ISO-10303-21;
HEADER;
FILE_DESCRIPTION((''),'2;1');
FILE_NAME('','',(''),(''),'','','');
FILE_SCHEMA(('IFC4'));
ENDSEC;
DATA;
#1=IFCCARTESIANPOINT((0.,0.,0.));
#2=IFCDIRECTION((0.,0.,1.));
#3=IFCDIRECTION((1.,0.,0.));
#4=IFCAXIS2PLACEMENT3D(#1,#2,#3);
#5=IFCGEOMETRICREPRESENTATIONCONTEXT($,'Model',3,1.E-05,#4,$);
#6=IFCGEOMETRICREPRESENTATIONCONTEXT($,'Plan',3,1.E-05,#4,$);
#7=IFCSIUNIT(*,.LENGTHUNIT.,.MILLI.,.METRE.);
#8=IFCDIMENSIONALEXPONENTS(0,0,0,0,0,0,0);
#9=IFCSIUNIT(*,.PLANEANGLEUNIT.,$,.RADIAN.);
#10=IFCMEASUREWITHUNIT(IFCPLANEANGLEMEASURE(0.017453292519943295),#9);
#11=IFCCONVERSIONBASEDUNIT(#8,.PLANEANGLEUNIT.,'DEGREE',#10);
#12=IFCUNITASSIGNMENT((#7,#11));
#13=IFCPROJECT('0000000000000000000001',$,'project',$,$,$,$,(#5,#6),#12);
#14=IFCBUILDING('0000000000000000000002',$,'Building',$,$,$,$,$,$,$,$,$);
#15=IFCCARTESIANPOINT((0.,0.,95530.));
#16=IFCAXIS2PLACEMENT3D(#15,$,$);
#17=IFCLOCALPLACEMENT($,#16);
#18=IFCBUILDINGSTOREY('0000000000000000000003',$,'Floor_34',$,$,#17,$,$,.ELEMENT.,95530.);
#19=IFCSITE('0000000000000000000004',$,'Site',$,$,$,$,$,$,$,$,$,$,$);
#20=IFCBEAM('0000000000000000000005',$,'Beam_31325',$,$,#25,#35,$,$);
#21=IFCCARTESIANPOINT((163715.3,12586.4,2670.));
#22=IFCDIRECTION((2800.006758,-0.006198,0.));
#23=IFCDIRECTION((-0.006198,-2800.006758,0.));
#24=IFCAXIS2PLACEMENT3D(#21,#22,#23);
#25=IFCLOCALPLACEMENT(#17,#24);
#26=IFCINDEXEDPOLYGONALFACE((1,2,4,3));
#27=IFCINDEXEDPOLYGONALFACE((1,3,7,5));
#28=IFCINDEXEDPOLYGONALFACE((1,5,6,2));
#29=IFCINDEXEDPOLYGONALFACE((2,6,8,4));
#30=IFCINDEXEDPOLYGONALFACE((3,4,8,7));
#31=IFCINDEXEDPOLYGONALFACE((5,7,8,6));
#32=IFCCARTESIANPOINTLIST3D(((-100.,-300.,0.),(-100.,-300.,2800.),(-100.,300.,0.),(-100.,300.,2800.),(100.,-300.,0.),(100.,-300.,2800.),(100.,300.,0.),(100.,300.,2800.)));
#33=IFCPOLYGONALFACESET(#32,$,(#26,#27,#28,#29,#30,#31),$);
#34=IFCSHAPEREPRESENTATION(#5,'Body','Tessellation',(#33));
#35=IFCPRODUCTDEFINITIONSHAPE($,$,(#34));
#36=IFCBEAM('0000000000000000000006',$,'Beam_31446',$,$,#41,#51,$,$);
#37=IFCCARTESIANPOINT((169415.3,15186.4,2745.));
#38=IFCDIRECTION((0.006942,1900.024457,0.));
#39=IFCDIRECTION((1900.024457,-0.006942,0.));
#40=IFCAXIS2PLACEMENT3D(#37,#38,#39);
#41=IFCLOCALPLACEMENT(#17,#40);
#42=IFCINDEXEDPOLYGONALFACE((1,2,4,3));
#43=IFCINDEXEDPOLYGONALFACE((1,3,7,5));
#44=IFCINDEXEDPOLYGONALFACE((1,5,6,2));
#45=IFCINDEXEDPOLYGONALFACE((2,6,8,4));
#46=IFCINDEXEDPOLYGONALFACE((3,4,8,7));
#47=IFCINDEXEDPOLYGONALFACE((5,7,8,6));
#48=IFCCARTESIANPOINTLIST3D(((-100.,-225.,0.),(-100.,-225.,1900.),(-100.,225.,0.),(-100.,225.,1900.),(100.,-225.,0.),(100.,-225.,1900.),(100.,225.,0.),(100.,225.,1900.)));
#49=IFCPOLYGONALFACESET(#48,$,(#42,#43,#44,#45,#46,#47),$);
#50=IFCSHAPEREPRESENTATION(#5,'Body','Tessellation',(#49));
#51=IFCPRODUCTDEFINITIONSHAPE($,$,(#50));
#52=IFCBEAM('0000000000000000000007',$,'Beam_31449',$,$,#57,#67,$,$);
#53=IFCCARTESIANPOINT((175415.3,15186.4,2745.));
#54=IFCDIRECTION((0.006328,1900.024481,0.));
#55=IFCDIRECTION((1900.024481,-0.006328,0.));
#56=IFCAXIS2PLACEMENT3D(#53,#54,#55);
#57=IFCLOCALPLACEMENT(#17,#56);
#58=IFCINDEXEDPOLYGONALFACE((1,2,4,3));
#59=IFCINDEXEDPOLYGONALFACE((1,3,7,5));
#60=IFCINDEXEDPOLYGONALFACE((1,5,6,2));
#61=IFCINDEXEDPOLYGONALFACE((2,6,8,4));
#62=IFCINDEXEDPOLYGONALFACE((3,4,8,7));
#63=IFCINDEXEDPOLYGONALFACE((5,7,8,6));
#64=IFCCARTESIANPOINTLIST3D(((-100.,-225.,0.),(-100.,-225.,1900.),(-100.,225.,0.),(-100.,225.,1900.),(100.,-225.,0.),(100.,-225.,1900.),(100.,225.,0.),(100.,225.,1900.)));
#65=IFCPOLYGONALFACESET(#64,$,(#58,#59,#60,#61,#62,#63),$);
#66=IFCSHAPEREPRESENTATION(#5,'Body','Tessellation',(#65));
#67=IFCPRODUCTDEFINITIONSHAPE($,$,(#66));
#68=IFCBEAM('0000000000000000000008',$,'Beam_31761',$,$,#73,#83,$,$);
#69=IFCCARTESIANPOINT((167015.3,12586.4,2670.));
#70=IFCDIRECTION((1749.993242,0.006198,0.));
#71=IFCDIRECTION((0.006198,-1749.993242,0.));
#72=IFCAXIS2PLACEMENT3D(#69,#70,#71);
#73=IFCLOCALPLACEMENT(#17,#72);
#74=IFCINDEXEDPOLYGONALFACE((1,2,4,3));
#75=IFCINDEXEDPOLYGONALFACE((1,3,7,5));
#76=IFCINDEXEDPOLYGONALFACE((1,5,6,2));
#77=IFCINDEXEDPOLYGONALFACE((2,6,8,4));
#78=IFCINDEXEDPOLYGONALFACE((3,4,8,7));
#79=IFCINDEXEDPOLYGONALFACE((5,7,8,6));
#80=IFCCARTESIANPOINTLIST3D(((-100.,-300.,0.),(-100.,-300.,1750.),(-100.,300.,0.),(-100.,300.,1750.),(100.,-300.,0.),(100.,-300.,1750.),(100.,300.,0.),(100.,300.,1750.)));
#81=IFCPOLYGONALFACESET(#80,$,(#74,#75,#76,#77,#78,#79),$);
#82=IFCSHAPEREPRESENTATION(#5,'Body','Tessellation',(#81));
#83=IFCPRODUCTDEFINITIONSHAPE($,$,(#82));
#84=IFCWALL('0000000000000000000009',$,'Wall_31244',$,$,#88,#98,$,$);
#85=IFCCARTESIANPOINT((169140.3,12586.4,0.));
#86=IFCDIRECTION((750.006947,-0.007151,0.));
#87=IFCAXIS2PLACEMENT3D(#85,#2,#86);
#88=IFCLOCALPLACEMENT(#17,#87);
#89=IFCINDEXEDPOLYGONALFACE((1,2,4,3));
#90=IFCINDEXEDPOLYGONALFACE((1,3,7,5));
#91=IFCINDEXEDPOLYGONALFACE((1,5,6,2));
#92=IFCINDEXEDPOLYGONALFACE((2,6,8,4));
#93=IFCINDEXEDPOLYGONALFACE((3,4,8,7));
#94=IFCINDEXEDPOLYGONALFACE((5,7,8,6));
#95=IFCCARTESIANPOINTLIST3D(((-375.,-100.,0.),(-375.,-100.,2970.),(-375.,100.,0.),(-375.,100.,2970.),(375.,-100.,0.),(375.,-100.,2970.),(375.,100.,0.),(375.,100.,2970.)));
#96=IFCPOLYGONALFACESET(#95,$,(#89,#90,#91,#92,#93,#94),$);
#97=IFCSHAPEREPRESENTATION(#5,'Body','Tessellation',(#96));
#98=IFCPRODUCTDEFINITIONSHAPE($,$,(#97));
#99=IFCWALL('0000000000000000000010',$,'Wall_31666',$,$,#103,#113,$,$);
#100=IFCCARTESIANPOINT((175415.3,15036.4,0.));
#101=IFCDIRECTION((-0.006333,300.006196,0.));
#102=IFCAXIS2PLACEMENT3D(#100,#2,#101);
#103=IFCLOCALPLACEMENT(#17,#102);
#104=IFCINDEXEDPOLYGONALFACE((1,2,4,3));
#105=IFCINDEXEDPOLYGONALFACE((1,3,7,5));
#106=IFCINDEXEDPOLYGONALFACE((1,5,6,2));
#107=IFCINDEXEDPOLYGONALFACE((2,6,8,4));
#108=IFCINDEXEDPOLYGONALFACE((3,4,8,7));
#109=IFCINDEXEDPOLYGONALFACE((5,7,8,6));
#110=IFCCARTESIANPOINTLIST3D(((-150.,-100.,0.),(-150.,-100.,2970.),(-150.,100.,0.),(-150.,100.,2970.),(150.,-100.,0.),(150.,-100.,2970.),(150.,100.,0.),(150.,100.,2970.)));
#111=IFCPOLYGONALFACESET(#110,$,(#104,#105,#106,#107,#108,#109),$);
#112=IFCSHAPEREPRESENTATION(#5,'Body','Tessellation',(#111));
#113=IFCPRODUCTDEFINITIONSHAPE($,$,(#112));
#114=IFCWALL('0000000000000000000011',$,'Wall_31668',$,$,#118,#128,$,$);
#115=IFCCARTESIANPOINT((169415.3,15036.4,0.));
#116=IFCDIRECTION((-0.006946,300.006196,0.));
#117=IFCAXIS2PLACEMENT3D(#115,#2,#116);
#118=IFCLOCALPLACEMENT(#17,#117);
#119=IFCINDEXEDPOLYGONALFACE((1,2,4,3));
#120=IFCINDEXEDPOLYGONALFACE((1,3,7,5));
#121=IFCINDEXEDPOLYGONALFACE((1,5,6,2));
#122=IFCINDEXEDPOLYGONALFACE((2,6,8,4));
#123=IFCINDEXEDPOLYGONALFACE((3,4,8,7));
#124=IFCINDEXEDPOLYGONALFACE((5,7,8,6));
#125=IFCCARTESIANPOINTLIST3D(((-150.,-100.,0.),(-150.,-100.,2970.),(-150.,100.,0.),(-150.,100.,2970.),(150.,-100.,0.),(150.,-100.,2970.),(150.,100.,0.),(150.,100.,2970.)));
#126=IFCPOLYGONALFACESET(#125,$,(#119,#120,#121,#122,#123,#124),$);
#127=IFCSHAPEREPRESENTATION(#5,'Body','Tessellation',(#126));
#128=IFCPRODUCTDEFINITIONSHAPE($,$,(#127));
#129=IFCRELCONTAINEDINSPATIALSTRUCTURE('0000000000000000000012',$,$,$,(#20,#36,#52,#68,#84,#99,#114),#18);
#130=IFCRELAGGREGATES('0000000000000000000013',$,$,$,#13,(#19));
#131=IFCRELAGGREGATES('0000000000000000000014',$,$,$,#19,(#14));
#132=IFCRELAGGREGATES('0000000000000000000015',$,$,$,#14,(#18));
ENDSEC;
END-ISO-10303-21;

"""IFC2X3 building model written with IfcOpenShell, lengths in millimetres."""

from ifc_helpers import new_model, entity, si_unit, converted_unit, frame, origin_with_axes, origin_2d, place, context, project, spatial, rectangle, extrude, element, save


model = new_model("IFC2X3")

# Units and contexts
model_context = context("Model", 3, precision=1e-05, world=origin_with_axes())
plan_context = context("Plan", 3, precision=1e-05, world=origin_with_axes())
ifc_project = project(units=[si_unit("LENGTHUNIT", "METRE", prefix="MILLI"), converted_unit("PLANEANGLEUNIT", "DEGREE", entity("IfcPlaneAngleMeasure", 0.017453292519943295), si_unit("PLANEANGLEUNIT", "RADIAN"), dimensions=[0, 0, 0, 0, 0, 0, 0])], contexts=[model_context, plan_context])

# Site, building, storey
site = spatial("IfcSite", under=ifc_project, Name="Site")
building = spatial("IfcBuilding", under=site, Name="Building")
storey_placement = place(None, frame((0.0, 0.0, 95530.0)))
storey = spatial("IfcBuildingStorey", under=building, at=storey_placement, Name="Floor_34", CompositionType="ELEMENT", Elevation=95530.0)

# Beams
beam_1_placement = place(storey_placement, frame((163715.3, 12586.4, 2670.0), z_axis=(2800.006758, -0.006198, 0.0), x_axis=(-0.006198, -2800.006758, 0.0)))
element("IfcBeam", 1, at=beam_1_placement, inside=storey, Name="Beam_31325", context=model_context, shape_type="SweptSolid", body=[
    extrude(rectangle(XDim=200.0, YDim=600.0, at=origin_2d()), origin_with_axes(), (0.0, 0.0, 1.0), 2800.0),
])
beam_2_placement = place(storey_placement, frame((169415.3, 15186.4, 2745.0), z_axis=(0.006942, 1900.024457, 0.0), x_axis=(1900.024457, -0.006942, 0.0)))
element("IfcBeam", 2, at=beam_2_placement, inside=storey, Name="Beam_31446", context=model_context, shape_type="SweptSolid", body=[
    extrude(rectangle(XDim=200.0, YDim=450.0, at=origin_2d()), origin_with_axes(), (0.0, 0.0, 1.0), 1900.0),
])
beam_3_placement = place(storey_placement, frame((175415.3, 15186.4, 2745.0), z_axis=(0.006328, 1900.024481, 0.0), x_axis=(1900.024481, -0.006328, 0.0)))
element("IfcBeam", 3, at=beam_3_placement, inside=storey, Name="Beam_31449", context=model_context, shape_type="SweptSolid", body=[
    extrude(rectangle(XDim=200.0, YDim=450.0, at=origin_2d()), origin_with_axes(), (0.0, 0.0, 1.0), 1900.0),
])
beam_4_placement = place(storey_placement, frame((167015.3, 12586.4, 2670.0), z_axis=(1749.993242, 0.006198, 0.0), x_axis=(0.006198, -1749.993242, 0.0)))
element("IfcBeam", 4, at=beam_4_placement, inside=storey, Name="Beam_31761", context=model_context, shape_type="SweptSolid", body=[
    extrude(rectangle(XDim=200.0, YDim=600.0, at=origin_2d()), origin_with_axes(), (0.0, 0.0, 1.0), 1750.0),
])

# Walls
wall_1_placement = place(storey_placement, frame((169140.3, 12586.4, 0.0), z_axis=(0.0, 0.0, 1.0), x_axis=(750.006947, -0.007151, 0.0)))
element("IfcWall", 5, at=wall_1_placement, inside=storey, Name="Wall_31244", context=model_context, shape_type="SweptSolid", body=[
    extrude(rectangle(XDim=750.0, YDim=200.0, at=origin_2d()), origin_with_axes(), (0.0, 0.0, 1.0), 2970.0),
])
wall_2_placement = place(storey_placement, frame((175415.3, 15036.4, 0.0), z_axis=(0.0, 0.0, 1.0), x_axis=(-0.006333, 300.006196, 0.0)))
element("IfcWall", 6, at=wall_2_placement, inside=storey, Name="Wall_31666", context=model_context, shape_type="SweptSolid", body=[
    extrude(rectangle(XDim=300.0, YDim=200.0, at=origin_2d()), origin_with_axes(), (0.0, 0.0, 1.0), 2970.0),
])
wall_3_placement = place(storey_placement, frame((169415.3, 15036.4, 0.0), z_axis=(0.0, 0.0, 1.0), x_axis=(-0.006946, 300.006196, 0.0)))
element("IfcWall", 7, at=wall_3_placement, inside=storey, Name="Wall_31668", context=model_context, shape_type="SweptSolid", body=[
    extrude(rectangle(XDim=300.0, YDim=200.0, at=origin_2d()), origin_with_axes(), (0.0, 0.0, 1.0), 2970.0),
])

save(model, "model.ifc")
